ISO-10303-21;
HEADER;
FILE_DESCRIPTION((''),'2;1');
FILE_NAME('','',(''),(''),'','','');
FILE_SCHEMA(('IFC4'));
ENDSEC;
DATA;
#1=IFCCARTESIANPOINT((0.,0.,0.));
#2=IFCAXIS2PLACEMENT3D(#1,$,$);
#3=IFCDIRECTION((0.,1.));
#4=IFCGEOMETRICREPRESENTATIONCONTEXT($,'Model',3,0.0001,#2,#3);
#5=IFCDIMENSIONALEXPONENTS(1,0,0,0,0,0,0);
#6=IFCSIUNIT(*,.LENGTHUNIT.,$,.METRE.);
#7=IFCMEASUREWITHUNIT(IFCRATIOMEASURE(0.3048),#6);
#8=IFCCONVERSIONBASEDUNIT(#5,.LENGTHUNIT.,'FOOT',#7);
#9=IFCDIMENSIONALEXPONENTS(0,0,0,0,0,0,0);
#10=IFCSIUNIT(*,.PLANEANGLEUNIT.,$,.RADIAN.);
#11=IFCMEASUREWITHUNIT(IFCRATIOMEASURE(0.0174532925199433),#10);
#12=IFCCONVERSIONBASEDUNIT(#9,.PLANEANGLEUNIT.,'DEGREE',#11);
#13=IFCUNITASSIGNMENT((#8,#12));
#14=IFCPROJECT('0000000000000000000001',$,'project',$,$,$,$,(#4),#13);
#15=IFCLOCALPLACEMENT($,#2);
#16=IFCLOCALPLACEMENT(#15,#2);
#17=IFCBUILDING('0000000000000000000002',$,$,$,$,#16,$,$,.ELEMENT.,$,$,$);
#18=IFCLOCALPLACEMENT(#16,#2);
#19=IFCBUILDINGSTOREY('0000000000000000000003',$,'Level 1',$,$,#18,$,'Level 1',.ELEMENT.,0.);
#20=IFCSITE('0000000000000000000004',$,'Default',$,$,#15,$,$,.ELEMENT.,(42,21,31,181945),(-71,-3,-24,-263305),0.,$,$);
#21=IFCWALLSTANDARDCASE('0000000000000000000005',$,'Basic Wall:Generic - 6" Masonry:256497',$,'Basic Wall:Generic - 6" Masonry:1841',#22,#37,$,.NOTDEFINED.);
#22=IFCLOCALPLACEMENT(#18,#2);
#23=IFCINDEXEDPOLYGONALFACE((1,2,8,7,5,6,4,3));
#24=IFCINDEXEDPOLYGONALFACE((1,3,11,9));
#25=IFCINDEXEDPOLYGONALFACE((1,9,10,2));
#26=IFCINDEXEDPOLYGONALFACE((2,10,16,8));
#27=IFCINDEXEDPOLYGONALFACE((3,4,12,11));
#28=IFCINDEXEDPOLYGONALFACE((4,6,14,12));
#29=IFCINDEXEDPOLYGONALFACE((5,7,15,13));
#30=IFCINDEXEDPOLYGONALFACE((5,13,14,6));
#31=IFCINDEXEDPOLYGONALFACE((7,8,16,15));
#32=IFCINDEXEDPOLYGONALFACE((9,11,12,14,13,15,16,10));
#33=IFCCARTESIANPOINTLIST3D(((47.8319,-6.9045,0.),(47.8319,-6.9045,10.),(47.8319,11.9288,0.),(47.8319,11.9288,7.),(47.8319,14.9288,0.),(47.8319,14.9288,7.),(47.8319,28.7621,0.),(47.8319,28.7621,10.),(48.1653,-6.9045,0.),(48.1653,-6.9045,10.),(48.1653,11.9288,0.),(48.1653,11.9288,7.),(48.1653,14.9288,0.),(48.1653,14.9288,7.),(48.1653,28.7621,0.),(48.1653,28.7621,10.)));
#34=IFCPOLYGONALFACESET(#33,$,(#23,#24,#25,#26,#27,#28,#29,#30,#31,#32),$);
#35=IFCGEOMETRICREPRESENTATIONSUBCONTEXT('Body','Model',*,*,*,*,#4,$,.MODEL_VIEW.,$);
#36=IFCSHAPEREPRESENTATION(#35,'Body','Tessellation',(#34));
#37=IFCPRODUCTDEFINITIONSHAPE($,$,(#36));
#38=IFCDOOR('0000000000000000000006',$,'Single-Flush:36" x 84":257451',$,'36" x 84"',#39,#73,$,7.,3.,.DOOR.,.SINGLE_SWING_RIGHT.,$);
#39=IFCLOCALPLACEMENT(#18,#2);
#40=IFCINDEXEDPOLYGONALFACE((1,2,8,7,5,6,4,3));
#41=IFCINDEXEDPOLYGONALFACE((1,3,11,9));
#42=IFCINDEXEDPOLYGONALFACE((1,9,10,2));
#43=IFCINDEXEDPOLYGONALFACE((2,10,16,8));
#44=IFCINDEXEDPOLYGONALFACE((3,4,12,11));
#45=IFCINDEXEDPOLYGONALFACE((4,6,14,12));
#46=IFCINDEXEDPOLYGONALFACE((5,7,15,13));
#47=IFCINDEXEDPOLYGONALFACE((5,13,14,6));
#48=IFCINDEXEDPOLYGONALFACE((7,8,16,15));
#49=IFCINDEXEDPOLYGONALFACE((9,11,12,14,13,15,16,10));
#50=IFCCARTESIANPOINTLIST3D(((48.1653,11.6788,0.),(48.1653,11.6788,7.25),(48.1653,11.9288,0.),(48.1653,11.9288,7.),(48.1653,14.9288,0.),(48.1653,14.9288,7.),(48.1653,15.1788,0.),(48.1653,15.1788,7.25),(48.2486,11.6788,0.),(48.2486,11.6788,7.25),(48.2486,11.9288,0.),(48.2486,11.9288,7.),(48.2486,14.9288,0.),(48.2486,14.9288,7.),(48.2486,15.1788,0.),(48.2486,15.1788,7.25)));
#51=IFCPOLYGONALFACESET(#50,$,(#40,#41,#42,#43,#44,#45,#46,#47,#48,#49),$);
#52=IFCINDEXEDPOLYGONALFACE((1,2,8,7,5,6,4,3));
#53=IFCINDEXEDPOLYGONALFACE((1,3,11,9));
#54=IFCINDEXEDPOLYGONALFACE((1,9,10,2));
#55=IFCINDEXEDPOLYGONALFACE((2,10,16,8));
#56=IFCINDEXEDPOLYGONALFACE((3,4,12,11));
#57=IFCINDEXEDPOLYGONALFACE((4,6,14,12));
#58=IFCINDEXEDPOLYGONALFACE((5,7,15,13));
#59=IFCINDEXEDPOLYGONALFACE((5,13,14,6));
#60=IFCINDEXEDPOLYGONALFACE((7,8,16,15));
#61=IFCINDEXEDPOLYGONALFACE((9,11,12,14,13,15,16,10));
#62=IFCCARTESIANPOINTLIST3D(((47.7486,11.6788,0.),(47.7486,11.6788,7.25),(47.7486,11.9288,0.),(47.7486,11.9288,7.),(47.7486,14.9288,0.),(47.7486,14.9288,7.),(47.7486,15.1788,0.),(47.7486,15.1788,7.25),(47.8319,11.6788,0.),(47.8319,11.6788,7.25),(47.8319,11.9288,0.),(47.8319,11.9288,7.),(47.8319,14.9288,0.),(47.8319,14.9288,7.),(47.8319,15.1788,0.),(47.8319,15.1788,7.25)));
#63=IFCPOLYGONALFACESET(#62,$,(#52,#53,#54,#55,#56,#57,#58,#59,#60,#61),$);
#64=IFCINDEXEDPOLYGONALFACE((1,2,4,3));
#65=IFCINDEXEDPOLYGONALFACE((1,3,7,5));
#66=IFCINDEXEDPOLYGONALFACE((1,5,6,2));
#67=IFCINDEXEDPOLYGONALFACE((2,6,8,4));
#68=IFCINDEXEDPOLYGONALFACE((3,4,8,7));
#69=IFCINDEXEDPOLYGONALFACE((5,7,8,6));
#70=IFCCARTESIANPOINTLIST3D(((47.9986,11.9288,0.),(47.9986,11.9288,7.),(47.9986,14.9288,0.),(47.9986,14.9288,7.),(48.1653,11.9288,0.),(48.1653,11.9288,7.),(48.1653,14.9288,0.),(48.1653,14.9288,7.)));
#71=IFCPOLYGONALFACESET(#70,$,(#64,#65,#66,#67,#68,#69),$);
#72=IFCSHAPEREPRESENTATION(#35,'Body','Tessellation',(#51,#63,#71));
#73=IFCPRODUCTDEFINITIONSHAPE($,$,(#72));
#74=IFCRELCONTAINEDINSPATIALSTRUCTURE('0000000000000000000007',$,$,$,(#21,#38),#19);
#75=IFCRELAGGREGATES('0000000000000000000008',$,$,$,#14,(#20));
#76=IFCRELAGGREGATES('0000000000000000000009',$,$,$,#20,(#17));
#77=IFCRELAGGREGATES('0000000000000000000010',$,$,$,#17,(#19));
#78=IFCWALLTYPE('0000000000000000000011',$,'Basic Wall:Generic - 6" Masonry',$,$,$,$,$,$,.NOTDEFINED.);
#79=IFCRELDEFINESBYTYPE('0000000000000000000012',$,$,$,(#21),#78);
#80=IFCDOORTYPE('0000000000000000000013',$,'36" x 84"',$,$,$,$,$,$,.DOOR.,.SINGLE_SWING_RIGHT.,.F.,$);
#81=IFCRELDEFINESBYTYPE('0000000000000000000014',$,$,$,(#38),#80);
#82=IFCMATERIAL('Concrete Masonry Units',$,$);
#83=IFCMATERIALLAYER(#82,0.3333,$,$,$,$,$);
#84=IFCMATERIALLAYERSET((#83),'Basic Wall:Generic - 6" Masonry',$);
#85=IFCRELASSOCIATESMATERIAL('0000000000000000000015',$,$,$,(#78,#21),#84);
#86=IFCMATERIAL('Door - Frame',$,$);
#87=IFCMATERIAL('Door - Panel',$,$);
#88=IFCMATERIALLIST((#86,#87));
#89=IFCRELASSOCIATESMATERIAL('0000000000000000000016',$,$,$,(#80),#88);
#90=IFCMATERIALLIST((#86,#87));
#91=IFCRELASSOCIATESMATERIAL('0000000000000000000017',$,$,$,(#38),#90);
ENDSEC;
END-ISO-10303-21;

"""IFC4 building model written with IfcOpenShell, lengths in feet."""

from ifc_helpers import new_model, entity, si_unit, converted_unit, direction, frame, frame_2d, origin, place, context, subcontext, project, spatial, polyline, rectangle, outline, extrude, source, transform, mapped, material, material_list, layer, layer_set, layer_usage, type_object, type_shapes, element, fill, save


model = new_model("IFC4")

# Units and contexts
model_context = context("Model", 3, precision=0.0001, world=origin(), true_north=direction((0.0, 1.0)))
body_context = subcontext(model_context, "Body", "Model", "MODEL_VIEW")
ifc_project = project(units=[converted_unit("LENGTHUNIT", "FOOT", entity("IfcRatioMeasure", 0.3048), si_unit("LENGTHUNIT", "METRE"), dimensions=[1, 0, 0, 0, 0, 0, 0]), converted_unit("PLANEANGLEUNIT", "DEGREE", entity("IfcRatioMeasure", 0.0174532925199433), si_unit("PLANEANGLEUNIT", "RADIAN"), dimensions=[0, 0, 0, 0, 0, 0, 0])], contexts=[model_context])

# Site, building, storey
site_placement = place(None, origin())
site = spatial("IfcSite", under=ifc_project, at=site_placement, Name="Default", CompositionType="ELEMENT", RefLatitude=(42, 21, 31, 181945), RefLongitude=(-71, -3, -24, -263305), RefElevation=0.0)
building_placement = place(site_placement, origin())
building = spatial("IfcBuilding", under=site, at=building_placement, CompositionType="ELEMENT")
storey_placement = place(building_placement, origin())
storey = spatial("IfcBuildingStorey", under=building, at=storey_placement, Name="Level 1", LongName="Level 1", CompositionType="ELEMENT", Elevation=0.0)

# Wall, opening, door
ifc_material_1 = material(Name="Concrete Masonry Units")
ifc_layer = layer(ifc_material_1, 0.3333)
ifc_layer_set = layer_set([ifc_layer], Name="Basic Wall:Generic - 6\" Masonry")
ifc_layer_usage = layer_usage(ifc_layer_set, "AXIS2", "NEGATIVE", 0.1667)
wall_type = type_object("IfcWallType", Name="Basic Wall:Generic - 6\" Masonry", PredefinedType="NOTDEFINED", material=ifc_layer_set)
wall_placement = place(storey_placement, frame((47.9986, 28.7621, 0.0), z_axis=(0.0, 0.0, 1.0), x_axis=(0.0, -1.0, 0.0)))
wall = element("IfcWallStandardCase", 1, at=wall_placement, inside=storey, type_object=wall_type, material=ifc_layer_usage, Name="Basic Wall:Generic - 6\" Masonry:256497", ObjectType="Basic Wall:Generic - 6\" Masonry:1841", PredefinedType="NOTDEFINED", context=body_context, shape_type="SweptSolid", body=[
    extrude(rectangle(XDim=35.6667, YDim=0.3333, at=frame_2d((17.8333, 0.0), x_axis=(-1.0, 0.0))), origin(), (0.0, 0.0, 1.0), 10.0),
])
opening_placement = place(wall_placement, frame((13.8333, -0.1667, 0.0)))
opening = element("IfcOpeningElement", 2, at=opening_placement, cuts=wall, ObjectType="Opening", PredefinedType="OPENING", context=body_context, shape_type="SweptSolid", body=[
    extrude(rectangle(XDim=3.0, YDim=7.0, at=frame_2d((3.5, 1.5), x_axis=(0.0, 1.0))), frame((0.0, 0.0, 0.0), z_axis=(0.0, 1.0, 0.0), x_axis=(0.0, 0.0, 1.0)), (0.0, 0.0, 1.0), 0.3333),
])
ifc_material_2 = material(Name="Door - Frame")
ifc_material_3 = material(Name="Door - Panel")
ifc_material_list_1 = material_list([ifc_material_2, ifc_material_3])
ifc_material_list_2 = material_list([ifc_material_2, ifc_material_3])
door_type = type_object("IfcDoorType", Name="36\" x 84\"", OperationType="SINGLE_SWING_RIGHT", ParameterTakesPrecedence=False, PredefinedType="DOOR", material=ifc_material_list_2)
shared_shape = source(origin(), body_context, "Body", "SweptSolid", [
    extrude(outline(polyline([(-1.75, -3.6875), (1.75, -3.6875), (1.75, 3.5625), (1.5, 3.5625), (1.5, -3.4375), (-1.5, -3.4375), (-1.5, 3.5625), (-1.75, 3.5625), (-1.75, -3.6875)])), frame((1.5, 0.3333, 3.5625), z_axis=(0.0, 1.0, 0.0), x_axis=(1.0, 0.0, 0.0)), (0.0, 0.0, 1.0), 0.0833),
    extrude(outline(polyline([(-3.6875, -1.75), (3.5625, -1.75), (3.5625, -1.5), (-3.4375, -1.5), (-3.4375, 1.5), (3.5625, 1.5), (3.5625, 1.75), (-3.6875, 1.75), (-3.6875, -1.75)])), frame((1.5, -0.0833, 3.5625), z_axis=(0.0, 1.0, 0.0), x_axis=(0.0, 0.0, -1.0)), (0.0, 0.0, 1.0), 0.0833),
    extrude(rectangle(XDim=0.1667, YDim=3.0, at=frame_2d((0.0, 0.0), x_axis=(1.0, 0.0))), frame((1.5, 0.25, 0.0), z_axis=(0.0, 0.0, 1.0), x_axis=(0.0, 1.0, 0.0)), (0.0, 0.0, 1.0), 7.0),
])
type_shapes(door_type, [shared_shape])
door_placement = place(opening_placement, origin())
door = element("IfcDoor", 3, at=door_placement, inside=storey, type_object=door_type, material=ifc_material_list_1, Name="Single-Flush:36\" x 84\":257451", ObjectType="36\" x 84\"", OperationType="SINGLE_SWING_RIGHT", OverallHeight=7.0, OverallWidth=3.0, PredefinedType="DOOR", context=body_context, shape_type="MappedRepresentation", body=[
    mapped(shared_shape, transform((0.0, 0.0, 0.0), scale=1.0)),
])
fill(opening, door)

save(model, "model.ifc")
